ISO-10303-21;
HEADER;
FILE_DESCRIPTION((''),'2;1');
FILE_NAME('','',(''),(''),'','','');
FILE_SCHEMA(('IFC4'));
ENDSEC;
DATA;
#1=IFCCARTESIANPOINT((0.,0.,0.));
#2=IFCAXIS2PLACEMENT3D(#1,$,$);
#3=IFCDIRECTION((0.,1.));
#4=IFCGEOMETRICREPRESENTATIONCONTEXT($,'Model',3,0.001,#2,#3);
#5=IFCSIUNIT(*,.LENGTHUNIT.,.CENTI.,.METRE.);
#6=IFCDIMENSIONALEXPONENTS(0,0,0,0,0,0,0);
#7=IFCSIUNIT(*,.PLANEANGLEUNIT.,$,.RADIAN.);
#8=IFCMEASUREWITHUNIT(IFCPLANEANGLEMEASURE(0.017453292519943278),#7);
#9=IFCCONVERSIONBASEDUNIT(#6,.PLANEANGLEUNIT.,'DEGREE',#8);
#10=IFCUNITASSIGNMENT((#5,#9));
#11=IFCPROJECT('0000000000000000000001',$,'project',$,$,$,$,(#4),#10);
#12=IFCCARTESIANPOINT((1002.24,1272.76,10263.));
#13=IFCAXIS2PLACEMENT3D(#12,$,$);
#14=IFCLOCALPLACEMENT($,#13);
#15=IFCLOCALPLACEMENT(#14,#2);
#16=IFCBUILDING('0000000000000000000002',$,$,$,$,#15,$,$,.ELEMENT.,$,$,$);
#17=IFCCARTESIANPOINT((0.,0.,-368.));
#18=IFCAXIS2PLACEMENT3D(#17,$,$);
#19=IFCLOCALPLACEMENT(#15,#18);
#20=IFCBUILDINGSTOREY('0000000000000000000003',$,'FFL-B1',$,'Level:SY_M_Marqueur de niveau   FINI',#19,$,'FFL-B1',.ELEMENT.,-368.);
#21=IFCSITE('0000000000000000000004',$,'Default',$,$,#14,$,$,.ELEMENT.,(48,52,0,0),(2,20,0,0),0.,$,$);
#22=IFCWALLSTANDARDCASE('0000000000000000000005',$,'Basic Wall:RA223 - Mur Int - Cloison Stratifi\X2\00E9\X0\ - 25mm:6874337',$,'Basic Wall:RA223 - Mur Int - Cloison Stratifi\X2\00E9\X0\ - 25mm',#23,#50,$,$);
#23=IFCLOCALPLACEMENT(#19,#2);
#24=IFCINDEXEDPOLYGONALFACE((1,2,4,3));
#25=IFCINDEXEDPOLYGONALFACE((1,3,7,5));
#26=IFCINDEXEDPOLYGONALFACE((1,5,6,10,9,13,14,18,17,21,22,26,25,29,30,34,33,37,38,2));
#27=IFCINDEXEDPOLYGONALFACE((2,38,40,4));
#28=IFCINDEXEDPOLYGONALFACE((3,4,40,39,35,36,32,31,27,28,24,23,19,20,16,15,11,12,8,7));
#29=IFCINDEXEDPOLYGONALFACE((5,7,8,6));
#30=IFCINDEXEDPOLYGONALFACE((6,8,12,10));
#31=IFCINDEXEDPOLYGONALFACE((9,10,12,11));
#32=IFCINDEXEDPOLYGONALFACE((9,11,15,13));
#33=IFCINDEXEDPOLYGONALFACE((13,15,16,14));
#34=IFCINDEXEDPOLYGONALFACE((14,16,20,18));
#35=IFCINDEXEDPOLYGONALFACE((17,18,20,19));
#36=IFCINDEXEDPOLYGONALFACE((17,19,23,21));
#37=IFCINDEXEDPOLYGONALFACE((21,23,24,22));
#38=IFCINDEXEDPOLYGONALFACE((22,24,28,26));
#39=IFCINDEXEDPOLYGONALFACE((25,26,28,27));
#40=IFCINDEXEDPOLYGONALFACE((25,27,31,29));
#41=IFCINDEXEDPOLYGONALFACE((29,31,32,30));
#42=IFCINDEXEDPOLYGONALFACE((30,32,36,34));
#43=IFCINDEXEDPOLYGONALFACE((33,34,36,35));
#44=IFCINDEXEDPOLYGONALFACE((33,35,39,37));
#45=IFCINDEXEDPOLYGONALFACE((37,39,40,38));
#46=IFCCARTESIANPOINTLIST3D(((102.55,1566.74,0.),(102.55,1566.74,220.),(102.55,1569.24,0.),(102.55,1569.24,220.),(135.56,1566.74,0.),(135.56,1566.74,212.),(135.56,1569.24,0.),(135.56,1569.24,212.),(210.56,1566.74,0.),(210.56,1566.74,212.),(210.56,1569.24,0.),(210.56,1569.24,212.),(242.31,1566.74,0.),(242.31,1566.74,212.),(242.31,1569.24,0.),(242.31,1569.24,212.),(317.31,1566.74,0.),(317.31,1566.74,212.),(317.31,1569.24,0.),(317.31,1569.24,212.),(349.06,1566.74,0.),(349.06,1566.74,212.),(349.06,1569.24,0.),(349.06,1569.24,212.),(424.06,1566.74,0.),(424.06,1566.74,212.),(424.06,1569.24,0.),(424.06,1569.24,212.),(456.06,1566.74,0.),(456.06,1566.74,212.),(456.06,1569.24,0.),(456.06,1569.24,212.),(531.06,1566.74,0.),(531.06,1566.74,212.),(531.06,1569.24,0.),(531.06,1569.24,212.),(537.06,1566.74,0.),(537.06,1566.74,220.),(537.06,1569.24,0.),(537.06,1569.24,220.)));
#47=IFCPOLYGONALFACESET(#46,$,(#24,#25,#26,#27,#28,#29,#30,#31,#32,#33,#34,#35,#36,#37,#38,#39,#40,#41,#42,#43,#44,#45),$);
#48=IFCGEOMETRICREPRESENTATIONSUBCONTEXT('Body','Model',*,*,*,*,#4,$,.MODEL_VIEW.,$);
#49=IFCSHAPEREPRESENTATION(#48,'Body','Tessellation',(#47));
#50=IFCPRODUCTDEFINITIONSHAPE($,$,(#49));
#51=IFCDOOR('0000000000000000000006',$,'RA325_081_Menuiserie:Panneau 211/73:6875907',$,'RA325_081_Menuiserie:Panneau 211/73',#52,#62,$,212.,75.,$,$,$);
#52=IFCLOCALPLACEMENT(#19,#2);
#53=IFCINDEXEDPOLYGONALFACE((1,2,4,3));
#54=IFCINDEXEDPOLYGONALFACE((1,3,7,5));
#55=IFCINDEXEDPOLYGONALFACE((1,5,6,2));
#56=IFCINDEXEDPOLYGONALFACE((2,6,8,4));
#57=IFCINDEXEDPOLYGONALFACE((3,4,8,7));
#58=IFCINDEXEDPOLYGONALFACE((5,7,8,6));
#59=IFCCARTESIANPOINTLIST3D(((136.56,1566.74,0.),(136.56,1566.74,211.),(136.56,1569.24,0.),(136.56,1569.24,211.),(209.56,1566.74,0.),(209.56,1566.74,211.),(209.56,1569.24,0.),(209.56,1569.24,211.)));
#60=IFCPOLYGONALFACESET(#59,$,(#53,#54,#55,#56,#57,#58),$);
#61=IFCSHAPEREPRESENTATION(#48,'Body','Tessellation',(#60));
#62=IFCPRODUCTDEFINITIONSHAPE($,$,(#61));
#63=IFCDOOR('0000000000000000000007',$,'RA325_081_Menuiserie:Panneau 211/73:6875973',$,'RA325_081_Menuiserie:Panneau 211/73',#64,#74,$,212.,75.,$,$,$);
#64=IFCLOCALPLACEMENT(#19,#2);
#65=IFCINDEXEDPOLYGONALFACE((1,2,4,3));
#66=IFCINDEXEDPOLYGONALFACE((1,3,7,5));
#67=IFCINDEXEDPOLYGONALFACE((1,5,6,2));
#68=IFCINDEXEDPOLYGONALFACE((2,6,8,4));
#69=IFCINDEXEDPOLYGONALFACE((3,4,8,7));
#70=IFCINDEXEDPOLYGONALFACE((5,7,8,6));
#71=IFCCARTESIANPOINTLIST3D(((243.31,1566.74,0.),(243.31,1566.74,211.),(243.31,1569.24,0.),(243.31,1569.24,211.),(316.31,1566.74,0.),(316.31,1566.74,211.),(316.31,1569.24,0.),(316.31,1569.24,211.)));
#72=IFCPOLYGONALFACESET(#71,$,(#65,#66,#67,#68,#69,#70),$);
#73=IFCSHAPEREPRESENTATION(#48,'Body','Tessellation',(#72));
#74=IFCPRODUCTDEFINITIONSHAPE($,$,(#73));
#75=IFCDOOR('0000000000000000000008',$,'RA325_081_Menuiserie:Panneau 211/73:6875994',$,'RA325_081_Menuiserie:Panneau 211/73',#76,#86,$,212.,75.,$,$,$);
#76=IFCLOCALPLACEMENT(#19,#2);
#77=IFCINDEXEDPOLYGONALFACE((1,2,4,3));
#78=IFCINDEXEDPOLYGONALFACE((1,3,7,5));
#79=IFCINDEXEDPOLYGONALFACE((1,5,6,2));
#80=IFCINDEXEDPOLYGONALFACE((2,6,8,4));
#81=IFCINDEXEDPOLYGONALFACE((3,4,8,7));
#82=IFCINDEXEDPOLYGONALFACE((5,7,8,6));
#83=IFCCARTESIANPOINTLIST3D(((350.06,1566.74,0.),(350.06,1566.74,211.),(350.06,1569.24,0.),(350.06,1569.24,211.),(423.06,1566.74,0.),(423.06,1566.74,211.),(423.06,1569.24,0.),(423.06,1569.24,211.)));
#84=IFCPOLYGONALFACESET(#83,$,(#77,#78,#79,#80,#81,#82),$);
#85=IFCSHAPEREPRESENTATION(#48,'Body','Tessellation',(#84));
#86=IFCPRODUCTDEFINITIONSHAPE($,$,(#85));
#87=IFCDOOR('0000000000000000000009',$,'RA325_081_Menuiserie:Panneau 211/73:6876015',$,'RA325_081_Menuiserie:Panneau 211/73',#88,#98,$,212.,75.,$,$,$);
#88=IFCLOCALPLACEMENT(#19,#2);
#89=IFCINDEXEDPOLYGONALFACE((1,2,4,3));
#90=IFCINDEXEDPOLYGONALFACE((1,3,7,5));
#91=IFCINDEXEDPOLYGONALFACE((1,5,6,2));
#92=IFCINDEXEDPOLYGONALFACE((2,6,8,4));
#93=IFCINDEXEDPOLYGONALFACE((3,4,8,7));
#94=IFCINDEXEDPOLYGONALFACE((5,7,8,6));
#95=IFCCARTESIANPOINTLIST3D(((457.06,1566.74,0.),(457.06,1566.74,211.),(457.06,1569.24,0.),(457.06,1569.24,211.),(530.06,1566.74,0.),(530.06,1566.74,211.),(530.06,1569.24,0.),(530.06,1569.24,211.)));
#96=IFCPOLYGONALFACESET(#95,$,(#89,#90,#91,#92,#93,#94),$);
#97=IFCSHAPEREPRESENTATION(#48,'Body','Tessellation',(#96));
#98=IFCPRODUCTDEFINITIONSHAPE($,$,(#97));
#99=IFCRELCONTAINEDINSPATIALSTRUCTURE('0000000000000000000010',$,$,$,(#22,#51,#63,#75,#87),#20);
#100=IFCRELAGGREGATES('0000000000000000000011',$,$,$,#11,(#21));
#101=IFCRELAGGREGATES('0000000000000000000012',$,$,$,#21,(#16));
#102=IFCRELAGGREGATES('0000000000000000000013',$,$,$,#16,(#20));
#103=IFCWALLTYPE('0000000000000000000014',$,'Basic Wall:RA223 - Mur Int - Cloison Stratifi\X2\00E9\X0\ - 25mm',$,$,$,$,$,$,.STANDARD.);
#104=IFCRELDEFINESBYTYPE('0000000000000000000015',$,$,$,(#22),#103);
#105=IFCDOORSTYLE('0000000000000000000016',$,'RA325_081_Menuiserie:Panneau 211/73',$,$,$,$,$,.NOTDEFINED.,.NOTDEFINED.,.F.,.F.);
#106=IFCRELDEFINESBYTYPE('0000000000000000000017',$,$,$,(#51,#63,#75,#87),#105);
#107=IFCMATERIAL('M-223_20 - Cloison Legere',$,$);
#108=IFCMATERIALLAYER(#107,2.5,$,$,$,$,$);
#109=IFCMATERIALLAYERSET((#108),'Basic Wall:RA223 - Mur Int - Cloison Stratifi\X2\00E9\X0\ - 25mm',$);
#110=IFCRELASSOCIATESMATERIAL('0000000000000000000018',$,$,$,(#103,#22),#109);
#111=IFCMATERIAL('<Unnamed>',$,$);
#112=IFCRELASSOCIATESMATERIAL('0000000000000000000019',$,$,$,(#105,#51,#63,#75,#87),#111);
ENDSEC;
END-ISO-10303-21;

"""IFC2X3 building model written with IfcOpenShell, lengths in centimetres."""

from ifc_helpers import new_model, entity, si_unit, converted_unit, direction, frame, frame_2d, origin, place, context, subcontext, project, spatial, rectangle, extrude, source, transform, mapped, material, layer, layer_set, layer_usage, type_object, type_shapes, element, fill, save


model = new_model("IFC2X3")

# Units and contexts
model_context = context("Model", 3, precision=0.001, world=origin(), true_north=direction((0.0, 1.0)))
body_context = subcontext(model_context, "Body", "Model", "MODEL_VIEW")
ifc_project = project(units=[si_unit("LENGTHUNIT", "METRE", prefix="CENTI"), converted_unit("PLANEANGLEUNIT", "DEGREE", entity("IfcPlaneAngleMeasure", 0.017453292519943278), si_unit("PLANEANGLEUNIT", "RADIAN"), dimensions=[0, 0, 0, 0, 0, 0, 0])], contexts=[model_context])

# Site, building, storey
site_placement = place(None, frame((1002.24, 1272.76, 10263.0)))
site = spatial("IfcSite", under=ifc_project, at=site_placement, Name="Default", CompositionType="ELEMENT", RefLatitude=(48, 52, 0, 0), RefLongitude=(2, 20, 0, 0), RefElevation=0.0)
building_placement = place(site_placement, origin())
building = spatial("IfcBuilding", under=site, at=building_placement, CompositionType="ELEMENT")
storey_placement = place(building_placement, frame((0.0, 0.0, -368.0)))
storey = spatial("IfcBuildingStorey", under=building, at=storey_placement, Name="FFL-B1", ObjectType="Level:SY_M_Marqueur de niveau   FINI", LongName="FFL-B1", CompositionType="ELEMENT", Elevation=-368.0)

# Wall, openings, doors
ifc_material_1 = material(Name="M-223_20 - Cloison Legere")
ifc_layer_1 = layer(ifc_material_1, 2.5)
ifc_layer_set_1 = layer_set([ifc_layer_1], Name="Basic Wall:RA223 - Mur Int - Cloison Stratifié - 25mm")
ifc_layer_usage_1 = layer_usage(ifc_layer_set_1, "AXIS2", "NEGATIVE", 1.25)
wall_type_1 = type_object("IfcWallType", Name="Basic Wall:RA223 - Mur Int - Cloison Stratifié - 25mm", PredefinedType="STANDARD", material=ifc_layer_set_1)
wall_1_placement = place(storey_placement, frame((537.06, 1567.99, 0.0), z_axis=(0.0, 0.0, 1.0), x_axis=(-1.0, 0.0, 0.0)))
wall_1 = element("IfcWallStandardCase", 1, at=wall_1_placement, inside=storey, type_object=wall_type_1, material=ifc_layer_usage_1, Name="Basic Wall:RA223 - Mur Int - Cloison Stratifié - 25mm:6874337", ObjectType="Basic Wall:RA223 - Mur Int - Cloison Stratifié - 25mm", context=body_context, shape_type="SweptSolid", body=[
    extrude(rectangle(XDim=434.51, YDim=2.5, at=frame_2d((217.25, 0.0), x_axis=(1.0, 0.0))), origin(), (0.0, 0.0, 1.0), 220.0),
])
opening_1_placement = place(wall_1_placement, frame((537.06, 1567.99, 0.0), z_axis=(0.0, 0.0, 1.0), x_axis=(-1.0, 0.0, 0.0)))
opening_1 = element("IfcOpeningElement", 2, at=opening_1_placement, cuts=wall_1, ObjectType="Opening", context=body_context, shape_type="SweptSolid", body=[
    extrude(rectangle(XDim=212.0, YDim=75.0, at=frame_2d((0.0, 0.0), x_axis=(0.0, 1.0))), frame((173.06, 1569.24, 106.0), z_axis=(0.0, -1.0, 0.0), x_axis=(-1.0, 0.0, 0.0)), (0.0, 0.0, 1.0), 2.5),
])
opening_2_placement = place(wall_1_placement, frame((537.06, 1567.99, 0.0), z_axis=(0.0, 0.0, 1.0), x_axis=(-1.0, 0.0, 0.0)))
opening_2 = element("IfcOpeningElement", 3, at=opening_2_placement, cuts=wall_1, ObjectType="Opening", context=body_context, shape_type="SweptSolid", body=[
    extrude(rectangle(XDim=212.0, YDim=75.0, at=frame_2d((0.0, 0.0), x_axis=(0.0, 1.0))), frame((279.81, 1569.24, 106.0), z_axis=(0.0, -1.0, 0.0), x_axis=(-1.0, 0.0, 0.0)), (0.0, 0.0, 1.0), 2.5),
])
opening_3_placement = place(wall_1_placement, frame((537.06, 1567.99, 0.0), z_axis=(0.0, 0.0, 1.0), x_axis=(-1.0, 0.0, 0.0)))
opening_3 = element("IfcOpeningElement", 4, at=opening_3_placement, cuts=wall_1, ObjectType="Opening", context=body_context, shape_type="SweptSolid", body=[
    extrude(rectangle(XDim=212.0, YDim=75.0, at=frame_2d((0.0, 0.0), x_axis=(0.0, 1.0))), frame((386.56, 1569.24, 106.0), z_axis=(0.0, -1.0, 0.0), x_axis=(-1.0, 0.0, 0.0)), (0.0, 0.0, 1.0), 2.5),
])
opening_4_placement = place(wall_1_placement, frame((537.06, 1567.99, 0.0), z_axis=(0.0, 0.0, 1.0), x_axis=(-1.0, 0.0, 0.0)))
opening_4 = element("IfcOpeningElement", 5, at=opening_4_placement, cuts=wall_1, ObjectType="Opening", context=body_context, shape_type="SweptSolid", body=[
    extrude(rectangle(XDim=212.0, YDim=75.0, at=frame_2d((0.0, 0.0), x_axis=(0.0, 1.0))), frame((493.56, 1569.24, 106.0), z_axis=(0.0, -1.0, 0.0), x_axis=(-1.0, 0.0, 0.0)), (0.0, 0.0, 1.0), 2.5),
])
ifc_material_2 = material(Name="<Unnamed>")
door_style_1 = type_object("IfcDoorStyle", Name="RA325_081_Menuiserie:Panneau 211/73", ConstructionType="NOTDEFINED", OperationType="NOTDEFINED", ParameterTakesPrecedence=False, Sizeable=False, material=ifc_material_2)
shared_shape_1 = source(origin(), body_context, "Body", "SweptSolid", [
    extrude(rectangle(XDim=2.5, YDim=73.0, at=frame_2d((0.0, 0.0), x_axis=(1.0, 0.0))), frame((37.5, 1.25, 0.0), z_axis=(0.0, 0.0, 1.0), x_axis=(0.0, -1.0, 0.0)), (0.0, 0.0, 1.0), 211.0),
])
type_shapes(door_style_1, [shared_shape_1])
door_1_placement = place(opening_1_placement, frame((135.56, 1566.74, 0.0)))
door_1 = element("IfcDoor", 6, at=door_1_placement, inside=storey, type_object=door_style_1, material=ifc_material_2, Name="RA325_081_Menuiserie:Panneau 211/73:6875907", ObjectType="RA325_081_Menuiserie:Panneau 211/73", OverallHeight=212.0, OverallWidth=75.0, context=body_context, shape_type="MappedRepresentation", body=[
    mapped(shared_shape_1, transform((0.0, 0.0, 0.0), scale=1.0)),
])
fill(opening_1, door_1)
door_2_placement = place(opening_2_placement, frame((242.31, 1566.74, 0.0)))
door_2 = element("IfcDoor", 7, at=door_2_placement, inside=storey, type_object=door_style_1, material=ifc_material_2, Name="RA325_081_Menuiserie:Panneau 211/73:6875973", ObjectType="RA325_081_Menuiserie:Panneau 211/73", OverallHeight=212.0, OverallWidth=75.0, context=body_context, shape_type="MappedRepresentation", body=[
    mapped(shared_shape_1, transform((0.0, 0.0, 0.0), scale=1.0)),
])
fill(opening_2, door_2)
door_3_placement = place(opening_3_placement, frame((349.06, 1566.74, 0.0)))
door_3 = element("IfcDoor", 8, at=door_3_placement, inside=storey, type_object=door_style_1, material=ifc_material_2, Name="RA325_081_Menuiserie:Panneau 211/73:6875994", ObjectType="RA325_081_Menuiserie:Panneau 211/73", OverallHeight=212.0, OverallWidth=75.0, context=body_context, shape_type="MappedRepresentation", body=[
    mapped(shared_shape_1, transform((0.0, 0.0, 0.0), scale=1.0)),
])
fill(opening_3, door_3)
door_4_placement = place(opening_4_placement, frame((456.06, 1566.74, 0.0)))
door_4 = element("IfcDoor", 9, at=door_4_placement, inside=storey, type_object=door_style_1, material=ifc_material_2, Name="RA325_081_Menuiserie:Panneau 211/73:6876015", ObjectType="RA325_081_Menuiserie:Panneau 211/73", OverallHeight=212.0, OverallWidth=75.0, context=body_context, shape_type="MappedRepresentation", body=[
    mapped(shared_shape_1, transform((0.0, 0.0, 0.0), scale=1.0)),
])
fill(opening_4, door_4)

save(model, "model.ifc")
